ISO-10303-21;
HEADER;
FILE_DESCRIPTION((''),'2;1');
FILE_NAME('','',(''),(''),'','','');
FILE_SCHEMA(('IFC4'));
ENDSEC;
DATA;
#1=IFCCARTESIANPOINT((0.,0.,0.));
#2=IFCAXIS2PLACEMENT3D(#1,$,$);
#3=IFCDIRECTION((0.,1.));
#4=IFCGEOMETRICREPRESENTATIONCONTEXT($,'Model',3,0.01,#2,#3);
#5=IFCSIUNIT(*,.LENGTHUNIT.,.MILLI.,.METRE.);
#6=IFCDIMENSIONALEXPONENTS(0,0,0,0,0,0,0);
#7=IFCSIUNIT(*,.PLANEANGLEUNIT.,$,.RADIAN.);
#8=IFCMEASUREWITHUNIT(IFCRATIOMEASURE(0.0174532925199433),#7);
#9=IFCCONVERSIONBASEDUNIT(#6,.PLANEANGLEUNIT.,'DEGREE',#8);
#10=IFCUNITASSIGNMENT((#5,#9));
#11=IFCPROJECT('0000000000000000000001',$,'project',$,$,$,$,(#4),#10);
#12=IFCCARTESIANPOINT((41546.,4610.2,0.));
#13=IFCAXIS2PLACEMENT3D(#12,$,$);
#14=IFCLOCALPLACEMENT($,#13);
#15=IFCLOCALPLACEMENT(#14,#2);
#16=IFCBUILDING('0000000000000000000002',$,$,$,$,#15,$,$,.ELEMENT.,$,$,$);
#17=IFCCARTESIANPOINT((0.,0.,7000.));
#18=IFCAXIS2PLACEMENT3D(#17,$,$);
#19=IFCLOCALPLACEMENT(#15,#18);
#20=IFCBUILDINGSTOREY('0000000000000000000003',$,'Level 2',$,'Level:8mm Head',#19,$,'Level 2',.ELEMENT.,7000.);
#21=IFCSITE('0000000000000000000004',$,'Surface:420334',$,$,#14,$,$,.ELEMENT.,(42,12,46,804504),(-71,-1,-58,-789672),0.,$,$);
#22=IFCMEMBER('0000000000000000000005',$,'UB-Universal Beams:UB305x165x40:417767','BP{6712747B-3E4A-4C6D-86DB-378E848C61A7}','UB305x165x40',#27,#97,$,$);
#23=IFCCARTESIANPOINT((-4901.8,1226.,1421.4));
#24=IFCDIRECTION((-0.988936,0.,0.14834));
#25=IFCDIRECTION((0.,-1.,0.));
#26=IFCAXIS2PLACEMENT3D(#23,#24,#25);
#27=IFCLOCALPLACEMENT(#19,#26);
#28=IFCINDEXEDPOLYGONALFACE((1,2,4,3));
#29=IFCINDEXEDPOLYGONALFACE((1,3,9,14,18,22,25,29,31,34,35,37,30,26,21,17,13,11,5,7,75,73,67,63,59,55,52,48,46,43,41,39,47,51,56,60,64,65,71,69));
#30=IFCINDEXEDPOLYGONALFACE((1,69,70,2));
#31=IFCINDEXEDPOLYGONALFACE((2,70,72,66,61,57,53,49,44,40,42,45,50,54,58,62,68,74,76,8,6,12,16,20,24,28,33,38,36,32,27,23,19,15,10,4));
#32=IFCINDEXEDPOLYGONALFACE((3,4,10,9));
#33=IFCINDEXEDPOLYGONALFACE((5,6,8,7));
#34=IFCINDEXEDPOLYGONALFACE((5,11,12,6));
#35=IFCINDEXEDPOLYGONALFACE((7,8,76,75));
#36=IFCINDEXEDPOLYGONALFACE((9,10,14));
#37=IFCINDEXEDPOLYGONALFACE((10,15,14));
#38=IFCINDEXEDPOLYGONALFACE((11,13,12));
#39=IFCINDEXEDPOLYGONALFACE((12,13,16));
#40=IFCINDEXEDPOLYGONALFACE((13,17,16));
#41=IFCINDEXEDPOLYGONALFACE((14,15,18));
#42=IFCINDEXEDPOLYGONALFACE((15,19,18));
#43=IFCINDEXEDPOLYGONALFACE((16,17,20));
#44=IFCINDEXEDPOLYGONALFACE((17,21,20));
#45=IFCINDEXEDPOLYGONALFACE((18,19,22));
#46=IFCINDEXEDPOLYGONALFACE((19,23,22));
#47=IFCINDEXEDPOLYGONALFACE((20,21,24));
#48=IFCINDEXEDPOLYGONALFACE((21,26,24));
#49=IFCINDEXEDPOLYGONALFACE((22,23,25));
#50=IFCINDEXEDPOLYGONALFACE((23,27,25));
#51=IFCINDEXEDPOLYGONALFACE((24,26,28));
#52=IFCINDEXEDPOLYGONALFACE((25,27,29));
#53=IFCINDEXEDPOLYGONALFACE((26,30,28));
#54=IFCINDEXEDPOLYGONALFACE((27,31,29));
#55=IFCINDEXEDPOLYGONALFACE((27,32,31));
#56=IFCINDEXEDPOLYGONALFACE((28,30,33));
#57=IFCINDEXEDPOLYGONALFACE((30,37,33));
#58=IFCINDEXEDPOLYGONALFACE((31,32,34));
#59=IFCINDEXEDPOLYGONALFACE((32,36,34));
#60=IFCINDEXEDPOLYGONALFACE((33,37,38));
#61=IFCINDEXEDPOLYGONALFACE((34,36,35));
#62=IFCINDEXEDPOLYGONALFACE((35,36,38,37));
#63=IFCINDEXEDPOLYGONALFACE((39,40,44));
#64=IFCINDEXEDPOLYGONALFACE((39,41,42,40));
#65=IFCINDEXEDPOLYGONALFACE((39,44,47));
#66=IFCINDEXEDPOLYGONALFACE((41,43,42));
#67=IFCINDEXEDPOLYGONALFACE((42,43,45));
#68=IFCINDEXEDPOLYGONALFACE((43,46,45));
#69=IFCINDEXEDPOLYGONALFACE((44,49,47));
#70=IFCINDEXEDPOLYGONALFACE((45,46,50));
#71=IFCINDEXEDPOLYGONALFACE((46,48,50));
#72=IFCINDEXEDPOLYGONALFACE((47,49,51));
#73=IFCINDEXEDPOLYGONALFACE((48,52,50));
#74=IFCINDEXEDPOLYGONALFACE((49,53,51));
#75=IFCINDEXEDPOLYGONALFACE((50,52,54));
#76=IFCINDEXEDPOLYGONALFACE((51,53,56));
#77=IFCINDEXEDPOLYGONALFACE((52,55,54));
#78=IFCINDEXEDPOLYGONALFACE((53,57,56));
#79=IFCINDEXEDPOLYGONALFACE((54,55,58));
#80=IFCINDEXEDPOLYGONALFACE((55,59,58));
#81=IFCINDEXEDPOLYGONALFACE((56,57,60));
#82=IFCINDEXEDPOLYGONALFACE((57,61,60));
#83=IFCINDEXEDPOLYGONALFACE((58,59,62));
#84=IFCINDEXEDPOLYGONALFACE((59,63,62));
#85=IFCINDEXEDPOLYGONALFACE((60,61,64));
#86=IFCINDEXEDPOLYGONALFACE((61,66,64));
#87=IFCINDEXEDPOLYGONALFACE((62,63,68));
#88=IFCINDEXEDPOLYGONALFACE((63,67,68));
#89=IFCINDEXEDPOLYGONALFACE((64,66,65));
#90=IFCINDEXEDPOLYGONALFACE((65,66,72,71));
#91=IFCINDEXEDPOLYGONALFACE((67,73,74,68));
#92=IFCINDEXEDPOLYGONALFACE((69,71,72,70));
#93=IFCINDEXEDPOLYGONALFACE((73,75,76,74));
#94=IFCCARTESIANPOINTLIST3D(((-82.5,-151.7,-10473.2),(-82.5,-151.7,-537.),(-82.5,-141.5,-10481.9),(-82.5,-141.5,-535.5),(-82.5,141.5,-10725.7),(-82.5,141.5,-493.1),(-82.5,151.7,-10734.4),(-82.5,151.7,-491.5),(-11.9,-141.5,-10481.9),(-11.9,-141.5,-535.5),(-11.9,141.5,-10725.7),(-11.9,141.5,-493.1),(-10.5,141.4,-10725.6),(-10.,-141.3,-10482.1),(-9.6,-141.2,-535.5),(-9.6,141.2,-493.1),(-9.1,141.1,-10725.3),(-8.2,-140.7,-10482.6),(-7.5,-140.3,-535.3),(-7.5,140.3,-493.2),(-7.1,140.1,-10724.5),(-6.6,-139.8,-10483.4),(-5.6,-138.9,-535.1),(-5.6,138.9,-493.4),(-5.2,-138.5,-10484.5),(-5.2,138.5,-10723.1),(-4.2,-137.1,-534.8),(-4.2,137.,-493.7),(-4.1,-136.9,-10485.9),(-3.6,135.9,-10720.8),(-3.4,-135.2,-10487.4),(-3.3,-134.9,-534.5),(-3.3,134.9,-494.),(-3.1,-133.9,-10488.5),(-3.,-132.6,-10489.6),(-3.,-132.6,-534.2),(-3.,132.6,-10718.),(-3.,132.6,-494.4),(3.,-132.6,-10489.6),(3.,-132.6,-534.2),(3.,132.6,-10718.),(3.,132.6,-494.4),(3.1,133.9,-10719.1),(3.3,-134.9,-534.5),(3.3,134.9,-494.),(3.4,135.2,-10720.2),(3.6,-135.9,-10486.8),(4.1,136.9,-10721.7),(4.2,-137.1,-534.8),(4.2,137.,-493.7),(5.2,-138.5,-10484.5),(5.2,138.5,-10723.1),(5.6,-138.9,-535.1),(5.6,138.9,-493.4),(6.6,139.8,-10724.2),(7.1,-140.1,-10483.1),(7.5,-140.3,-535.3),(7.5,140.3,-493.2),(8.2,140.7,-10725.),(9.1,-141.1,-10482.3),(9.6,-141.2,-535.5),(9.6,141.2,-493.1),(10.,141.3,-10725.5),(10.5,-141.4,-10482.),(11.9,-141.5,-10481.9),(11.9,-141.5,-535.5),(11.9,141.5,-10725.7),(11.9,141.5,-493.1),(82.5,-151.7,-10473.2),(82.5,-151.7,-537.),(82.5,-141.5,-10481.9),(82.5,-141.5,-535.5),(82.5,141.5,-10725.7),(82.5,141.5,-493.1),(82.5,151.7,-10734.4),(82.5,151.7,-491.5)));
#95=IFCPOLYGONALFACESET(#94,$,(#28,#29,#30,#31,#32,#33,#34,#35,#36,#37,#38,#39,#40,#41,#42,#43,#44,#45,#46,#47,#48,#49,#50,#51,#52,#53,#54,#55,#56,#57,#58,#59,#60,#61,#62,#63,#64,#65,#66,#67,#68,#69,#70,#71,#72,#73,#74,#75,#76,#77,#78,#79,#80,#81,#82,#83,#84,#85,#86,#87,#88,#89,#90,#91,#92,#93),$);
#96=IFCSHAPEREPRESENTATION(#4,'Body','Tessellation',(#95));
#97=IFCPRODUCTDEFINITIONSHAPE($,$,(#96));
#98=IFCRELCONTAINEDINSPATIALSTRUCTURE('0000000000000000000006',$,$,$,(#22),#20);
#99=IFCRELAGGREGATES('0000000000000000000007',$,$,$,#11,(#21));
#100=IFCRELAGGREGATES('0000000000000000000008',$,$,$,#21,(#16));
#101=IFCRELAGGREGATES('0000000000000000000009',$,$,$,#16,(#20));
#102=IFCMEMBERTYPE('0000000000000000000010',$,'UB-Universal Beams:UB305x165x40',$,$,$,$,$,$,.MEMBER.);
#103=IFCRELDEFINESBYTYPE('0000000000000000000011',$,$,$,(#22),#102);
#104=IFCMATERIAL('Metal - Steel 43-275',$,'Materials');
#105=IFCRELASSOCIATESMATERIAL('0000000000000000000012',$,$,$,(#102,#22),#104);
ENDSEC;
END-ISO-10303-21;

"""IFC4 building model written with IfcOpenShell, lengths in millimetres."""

from ifc_helpers import new_model, entity, si_unit, converted_unit, direction, frame, origin, origin_2d, place, context, project, spatial, i_section, extrude, clip, halfspace, material, type_object, element, save


model = new_model("IFC4")

# Units and contexts
model_context = context("Model", 3, precision=0.01, world=origin(), true_north=direction((0.0, 1.0)))
ifc_project = project(units=[si_unit("LENGTHUNIT", "METRE", prefix="MILLI"), converted_unit("PLANEANGLEUNIT", "DEGREE", entity("IfcRatioMeasure", 0.0174532925199433), si_unit("PLANEANGLEUNIT", "RADIAN"), dimensions=[0, 0, 0, 0, 0, 0, 0])], contexts=[model_context])

# Site, building, storey
site_placement = place(None, frame((41546.0, 4610.2, 0.0)))
site = spatial("IfcSite", under=ifc_project, at=site_placement, Name="Surface:420334", CompositionType="ELEMENT", RefLatitude=(42, 12, 46, 804504), RefLongitude=(-71, -1, -58, -789672), RefElevation=0.0)
building_placement = place(site_placement, origin())
building = spatial("IfcBuilding", under=site, at=building_placement, CompositionType="ELEMENT")
storey_placement = place(building_placement, frame((0.0, 0.0, 7000.0)))
storey = spatial("IfcBuildingStorey", under=building, at=storey_placement, Name="Level 2", ObjectType="Level:8mm Head", LongName="Level 2", CompositionType="ELEMENT", Elevation=7000.0)

# Member
ifc_material_1 = material(Name="Metal - Steel 43-275", Category="Materials")
member_type = type_object("IfcMemberType", Name="UB-Universal Beams:UB305x165x40", PredefinedType="MEMBER", material=ifc_material_1)
member_placement = place(storey_placement, frame((-4901.8, 1226.0, 1421.4), z_axis=(-0.988936, 0.0, 0.14834), x_axis=(0.0, -1.0, 0.0)))
element("IfcMember", 1, at=member_placement, inside=storey, type_object=member_type, material=ifc_material_1, Name="UB-Universal Beams:UB305x165x40:417767", Description="BP{6712747B-3E4A-4C6D-86DB-378E848C61A7}", ObjectType="UB305x165x40", context=model_context, shape_type="Clipping", body=[
    clip(clip(extrude(i_section(OverallWidth=165.0, OverallDepth=303.4, WebThickness=6.0, FlangeThickness=10.2, FilletRadius=8.9, at=origin_2d()), origin(), (0.0, 0.0, -1.0), 11362.7), halfspace(frame((1226.0, -8252.8, -1752.2), z_axis=(0.0, 0.14834, -0.988936), x_axis=(-1.0, 0.0, 0.0)), True)), halfspace(frame((1226.0, -6592.9, -4926.1), z_axis=(0.0, 0.652556, 0.75774), x_axis=(1.0, 0.0, 0.0)), True)),
])

save(model, "model.ifc")
